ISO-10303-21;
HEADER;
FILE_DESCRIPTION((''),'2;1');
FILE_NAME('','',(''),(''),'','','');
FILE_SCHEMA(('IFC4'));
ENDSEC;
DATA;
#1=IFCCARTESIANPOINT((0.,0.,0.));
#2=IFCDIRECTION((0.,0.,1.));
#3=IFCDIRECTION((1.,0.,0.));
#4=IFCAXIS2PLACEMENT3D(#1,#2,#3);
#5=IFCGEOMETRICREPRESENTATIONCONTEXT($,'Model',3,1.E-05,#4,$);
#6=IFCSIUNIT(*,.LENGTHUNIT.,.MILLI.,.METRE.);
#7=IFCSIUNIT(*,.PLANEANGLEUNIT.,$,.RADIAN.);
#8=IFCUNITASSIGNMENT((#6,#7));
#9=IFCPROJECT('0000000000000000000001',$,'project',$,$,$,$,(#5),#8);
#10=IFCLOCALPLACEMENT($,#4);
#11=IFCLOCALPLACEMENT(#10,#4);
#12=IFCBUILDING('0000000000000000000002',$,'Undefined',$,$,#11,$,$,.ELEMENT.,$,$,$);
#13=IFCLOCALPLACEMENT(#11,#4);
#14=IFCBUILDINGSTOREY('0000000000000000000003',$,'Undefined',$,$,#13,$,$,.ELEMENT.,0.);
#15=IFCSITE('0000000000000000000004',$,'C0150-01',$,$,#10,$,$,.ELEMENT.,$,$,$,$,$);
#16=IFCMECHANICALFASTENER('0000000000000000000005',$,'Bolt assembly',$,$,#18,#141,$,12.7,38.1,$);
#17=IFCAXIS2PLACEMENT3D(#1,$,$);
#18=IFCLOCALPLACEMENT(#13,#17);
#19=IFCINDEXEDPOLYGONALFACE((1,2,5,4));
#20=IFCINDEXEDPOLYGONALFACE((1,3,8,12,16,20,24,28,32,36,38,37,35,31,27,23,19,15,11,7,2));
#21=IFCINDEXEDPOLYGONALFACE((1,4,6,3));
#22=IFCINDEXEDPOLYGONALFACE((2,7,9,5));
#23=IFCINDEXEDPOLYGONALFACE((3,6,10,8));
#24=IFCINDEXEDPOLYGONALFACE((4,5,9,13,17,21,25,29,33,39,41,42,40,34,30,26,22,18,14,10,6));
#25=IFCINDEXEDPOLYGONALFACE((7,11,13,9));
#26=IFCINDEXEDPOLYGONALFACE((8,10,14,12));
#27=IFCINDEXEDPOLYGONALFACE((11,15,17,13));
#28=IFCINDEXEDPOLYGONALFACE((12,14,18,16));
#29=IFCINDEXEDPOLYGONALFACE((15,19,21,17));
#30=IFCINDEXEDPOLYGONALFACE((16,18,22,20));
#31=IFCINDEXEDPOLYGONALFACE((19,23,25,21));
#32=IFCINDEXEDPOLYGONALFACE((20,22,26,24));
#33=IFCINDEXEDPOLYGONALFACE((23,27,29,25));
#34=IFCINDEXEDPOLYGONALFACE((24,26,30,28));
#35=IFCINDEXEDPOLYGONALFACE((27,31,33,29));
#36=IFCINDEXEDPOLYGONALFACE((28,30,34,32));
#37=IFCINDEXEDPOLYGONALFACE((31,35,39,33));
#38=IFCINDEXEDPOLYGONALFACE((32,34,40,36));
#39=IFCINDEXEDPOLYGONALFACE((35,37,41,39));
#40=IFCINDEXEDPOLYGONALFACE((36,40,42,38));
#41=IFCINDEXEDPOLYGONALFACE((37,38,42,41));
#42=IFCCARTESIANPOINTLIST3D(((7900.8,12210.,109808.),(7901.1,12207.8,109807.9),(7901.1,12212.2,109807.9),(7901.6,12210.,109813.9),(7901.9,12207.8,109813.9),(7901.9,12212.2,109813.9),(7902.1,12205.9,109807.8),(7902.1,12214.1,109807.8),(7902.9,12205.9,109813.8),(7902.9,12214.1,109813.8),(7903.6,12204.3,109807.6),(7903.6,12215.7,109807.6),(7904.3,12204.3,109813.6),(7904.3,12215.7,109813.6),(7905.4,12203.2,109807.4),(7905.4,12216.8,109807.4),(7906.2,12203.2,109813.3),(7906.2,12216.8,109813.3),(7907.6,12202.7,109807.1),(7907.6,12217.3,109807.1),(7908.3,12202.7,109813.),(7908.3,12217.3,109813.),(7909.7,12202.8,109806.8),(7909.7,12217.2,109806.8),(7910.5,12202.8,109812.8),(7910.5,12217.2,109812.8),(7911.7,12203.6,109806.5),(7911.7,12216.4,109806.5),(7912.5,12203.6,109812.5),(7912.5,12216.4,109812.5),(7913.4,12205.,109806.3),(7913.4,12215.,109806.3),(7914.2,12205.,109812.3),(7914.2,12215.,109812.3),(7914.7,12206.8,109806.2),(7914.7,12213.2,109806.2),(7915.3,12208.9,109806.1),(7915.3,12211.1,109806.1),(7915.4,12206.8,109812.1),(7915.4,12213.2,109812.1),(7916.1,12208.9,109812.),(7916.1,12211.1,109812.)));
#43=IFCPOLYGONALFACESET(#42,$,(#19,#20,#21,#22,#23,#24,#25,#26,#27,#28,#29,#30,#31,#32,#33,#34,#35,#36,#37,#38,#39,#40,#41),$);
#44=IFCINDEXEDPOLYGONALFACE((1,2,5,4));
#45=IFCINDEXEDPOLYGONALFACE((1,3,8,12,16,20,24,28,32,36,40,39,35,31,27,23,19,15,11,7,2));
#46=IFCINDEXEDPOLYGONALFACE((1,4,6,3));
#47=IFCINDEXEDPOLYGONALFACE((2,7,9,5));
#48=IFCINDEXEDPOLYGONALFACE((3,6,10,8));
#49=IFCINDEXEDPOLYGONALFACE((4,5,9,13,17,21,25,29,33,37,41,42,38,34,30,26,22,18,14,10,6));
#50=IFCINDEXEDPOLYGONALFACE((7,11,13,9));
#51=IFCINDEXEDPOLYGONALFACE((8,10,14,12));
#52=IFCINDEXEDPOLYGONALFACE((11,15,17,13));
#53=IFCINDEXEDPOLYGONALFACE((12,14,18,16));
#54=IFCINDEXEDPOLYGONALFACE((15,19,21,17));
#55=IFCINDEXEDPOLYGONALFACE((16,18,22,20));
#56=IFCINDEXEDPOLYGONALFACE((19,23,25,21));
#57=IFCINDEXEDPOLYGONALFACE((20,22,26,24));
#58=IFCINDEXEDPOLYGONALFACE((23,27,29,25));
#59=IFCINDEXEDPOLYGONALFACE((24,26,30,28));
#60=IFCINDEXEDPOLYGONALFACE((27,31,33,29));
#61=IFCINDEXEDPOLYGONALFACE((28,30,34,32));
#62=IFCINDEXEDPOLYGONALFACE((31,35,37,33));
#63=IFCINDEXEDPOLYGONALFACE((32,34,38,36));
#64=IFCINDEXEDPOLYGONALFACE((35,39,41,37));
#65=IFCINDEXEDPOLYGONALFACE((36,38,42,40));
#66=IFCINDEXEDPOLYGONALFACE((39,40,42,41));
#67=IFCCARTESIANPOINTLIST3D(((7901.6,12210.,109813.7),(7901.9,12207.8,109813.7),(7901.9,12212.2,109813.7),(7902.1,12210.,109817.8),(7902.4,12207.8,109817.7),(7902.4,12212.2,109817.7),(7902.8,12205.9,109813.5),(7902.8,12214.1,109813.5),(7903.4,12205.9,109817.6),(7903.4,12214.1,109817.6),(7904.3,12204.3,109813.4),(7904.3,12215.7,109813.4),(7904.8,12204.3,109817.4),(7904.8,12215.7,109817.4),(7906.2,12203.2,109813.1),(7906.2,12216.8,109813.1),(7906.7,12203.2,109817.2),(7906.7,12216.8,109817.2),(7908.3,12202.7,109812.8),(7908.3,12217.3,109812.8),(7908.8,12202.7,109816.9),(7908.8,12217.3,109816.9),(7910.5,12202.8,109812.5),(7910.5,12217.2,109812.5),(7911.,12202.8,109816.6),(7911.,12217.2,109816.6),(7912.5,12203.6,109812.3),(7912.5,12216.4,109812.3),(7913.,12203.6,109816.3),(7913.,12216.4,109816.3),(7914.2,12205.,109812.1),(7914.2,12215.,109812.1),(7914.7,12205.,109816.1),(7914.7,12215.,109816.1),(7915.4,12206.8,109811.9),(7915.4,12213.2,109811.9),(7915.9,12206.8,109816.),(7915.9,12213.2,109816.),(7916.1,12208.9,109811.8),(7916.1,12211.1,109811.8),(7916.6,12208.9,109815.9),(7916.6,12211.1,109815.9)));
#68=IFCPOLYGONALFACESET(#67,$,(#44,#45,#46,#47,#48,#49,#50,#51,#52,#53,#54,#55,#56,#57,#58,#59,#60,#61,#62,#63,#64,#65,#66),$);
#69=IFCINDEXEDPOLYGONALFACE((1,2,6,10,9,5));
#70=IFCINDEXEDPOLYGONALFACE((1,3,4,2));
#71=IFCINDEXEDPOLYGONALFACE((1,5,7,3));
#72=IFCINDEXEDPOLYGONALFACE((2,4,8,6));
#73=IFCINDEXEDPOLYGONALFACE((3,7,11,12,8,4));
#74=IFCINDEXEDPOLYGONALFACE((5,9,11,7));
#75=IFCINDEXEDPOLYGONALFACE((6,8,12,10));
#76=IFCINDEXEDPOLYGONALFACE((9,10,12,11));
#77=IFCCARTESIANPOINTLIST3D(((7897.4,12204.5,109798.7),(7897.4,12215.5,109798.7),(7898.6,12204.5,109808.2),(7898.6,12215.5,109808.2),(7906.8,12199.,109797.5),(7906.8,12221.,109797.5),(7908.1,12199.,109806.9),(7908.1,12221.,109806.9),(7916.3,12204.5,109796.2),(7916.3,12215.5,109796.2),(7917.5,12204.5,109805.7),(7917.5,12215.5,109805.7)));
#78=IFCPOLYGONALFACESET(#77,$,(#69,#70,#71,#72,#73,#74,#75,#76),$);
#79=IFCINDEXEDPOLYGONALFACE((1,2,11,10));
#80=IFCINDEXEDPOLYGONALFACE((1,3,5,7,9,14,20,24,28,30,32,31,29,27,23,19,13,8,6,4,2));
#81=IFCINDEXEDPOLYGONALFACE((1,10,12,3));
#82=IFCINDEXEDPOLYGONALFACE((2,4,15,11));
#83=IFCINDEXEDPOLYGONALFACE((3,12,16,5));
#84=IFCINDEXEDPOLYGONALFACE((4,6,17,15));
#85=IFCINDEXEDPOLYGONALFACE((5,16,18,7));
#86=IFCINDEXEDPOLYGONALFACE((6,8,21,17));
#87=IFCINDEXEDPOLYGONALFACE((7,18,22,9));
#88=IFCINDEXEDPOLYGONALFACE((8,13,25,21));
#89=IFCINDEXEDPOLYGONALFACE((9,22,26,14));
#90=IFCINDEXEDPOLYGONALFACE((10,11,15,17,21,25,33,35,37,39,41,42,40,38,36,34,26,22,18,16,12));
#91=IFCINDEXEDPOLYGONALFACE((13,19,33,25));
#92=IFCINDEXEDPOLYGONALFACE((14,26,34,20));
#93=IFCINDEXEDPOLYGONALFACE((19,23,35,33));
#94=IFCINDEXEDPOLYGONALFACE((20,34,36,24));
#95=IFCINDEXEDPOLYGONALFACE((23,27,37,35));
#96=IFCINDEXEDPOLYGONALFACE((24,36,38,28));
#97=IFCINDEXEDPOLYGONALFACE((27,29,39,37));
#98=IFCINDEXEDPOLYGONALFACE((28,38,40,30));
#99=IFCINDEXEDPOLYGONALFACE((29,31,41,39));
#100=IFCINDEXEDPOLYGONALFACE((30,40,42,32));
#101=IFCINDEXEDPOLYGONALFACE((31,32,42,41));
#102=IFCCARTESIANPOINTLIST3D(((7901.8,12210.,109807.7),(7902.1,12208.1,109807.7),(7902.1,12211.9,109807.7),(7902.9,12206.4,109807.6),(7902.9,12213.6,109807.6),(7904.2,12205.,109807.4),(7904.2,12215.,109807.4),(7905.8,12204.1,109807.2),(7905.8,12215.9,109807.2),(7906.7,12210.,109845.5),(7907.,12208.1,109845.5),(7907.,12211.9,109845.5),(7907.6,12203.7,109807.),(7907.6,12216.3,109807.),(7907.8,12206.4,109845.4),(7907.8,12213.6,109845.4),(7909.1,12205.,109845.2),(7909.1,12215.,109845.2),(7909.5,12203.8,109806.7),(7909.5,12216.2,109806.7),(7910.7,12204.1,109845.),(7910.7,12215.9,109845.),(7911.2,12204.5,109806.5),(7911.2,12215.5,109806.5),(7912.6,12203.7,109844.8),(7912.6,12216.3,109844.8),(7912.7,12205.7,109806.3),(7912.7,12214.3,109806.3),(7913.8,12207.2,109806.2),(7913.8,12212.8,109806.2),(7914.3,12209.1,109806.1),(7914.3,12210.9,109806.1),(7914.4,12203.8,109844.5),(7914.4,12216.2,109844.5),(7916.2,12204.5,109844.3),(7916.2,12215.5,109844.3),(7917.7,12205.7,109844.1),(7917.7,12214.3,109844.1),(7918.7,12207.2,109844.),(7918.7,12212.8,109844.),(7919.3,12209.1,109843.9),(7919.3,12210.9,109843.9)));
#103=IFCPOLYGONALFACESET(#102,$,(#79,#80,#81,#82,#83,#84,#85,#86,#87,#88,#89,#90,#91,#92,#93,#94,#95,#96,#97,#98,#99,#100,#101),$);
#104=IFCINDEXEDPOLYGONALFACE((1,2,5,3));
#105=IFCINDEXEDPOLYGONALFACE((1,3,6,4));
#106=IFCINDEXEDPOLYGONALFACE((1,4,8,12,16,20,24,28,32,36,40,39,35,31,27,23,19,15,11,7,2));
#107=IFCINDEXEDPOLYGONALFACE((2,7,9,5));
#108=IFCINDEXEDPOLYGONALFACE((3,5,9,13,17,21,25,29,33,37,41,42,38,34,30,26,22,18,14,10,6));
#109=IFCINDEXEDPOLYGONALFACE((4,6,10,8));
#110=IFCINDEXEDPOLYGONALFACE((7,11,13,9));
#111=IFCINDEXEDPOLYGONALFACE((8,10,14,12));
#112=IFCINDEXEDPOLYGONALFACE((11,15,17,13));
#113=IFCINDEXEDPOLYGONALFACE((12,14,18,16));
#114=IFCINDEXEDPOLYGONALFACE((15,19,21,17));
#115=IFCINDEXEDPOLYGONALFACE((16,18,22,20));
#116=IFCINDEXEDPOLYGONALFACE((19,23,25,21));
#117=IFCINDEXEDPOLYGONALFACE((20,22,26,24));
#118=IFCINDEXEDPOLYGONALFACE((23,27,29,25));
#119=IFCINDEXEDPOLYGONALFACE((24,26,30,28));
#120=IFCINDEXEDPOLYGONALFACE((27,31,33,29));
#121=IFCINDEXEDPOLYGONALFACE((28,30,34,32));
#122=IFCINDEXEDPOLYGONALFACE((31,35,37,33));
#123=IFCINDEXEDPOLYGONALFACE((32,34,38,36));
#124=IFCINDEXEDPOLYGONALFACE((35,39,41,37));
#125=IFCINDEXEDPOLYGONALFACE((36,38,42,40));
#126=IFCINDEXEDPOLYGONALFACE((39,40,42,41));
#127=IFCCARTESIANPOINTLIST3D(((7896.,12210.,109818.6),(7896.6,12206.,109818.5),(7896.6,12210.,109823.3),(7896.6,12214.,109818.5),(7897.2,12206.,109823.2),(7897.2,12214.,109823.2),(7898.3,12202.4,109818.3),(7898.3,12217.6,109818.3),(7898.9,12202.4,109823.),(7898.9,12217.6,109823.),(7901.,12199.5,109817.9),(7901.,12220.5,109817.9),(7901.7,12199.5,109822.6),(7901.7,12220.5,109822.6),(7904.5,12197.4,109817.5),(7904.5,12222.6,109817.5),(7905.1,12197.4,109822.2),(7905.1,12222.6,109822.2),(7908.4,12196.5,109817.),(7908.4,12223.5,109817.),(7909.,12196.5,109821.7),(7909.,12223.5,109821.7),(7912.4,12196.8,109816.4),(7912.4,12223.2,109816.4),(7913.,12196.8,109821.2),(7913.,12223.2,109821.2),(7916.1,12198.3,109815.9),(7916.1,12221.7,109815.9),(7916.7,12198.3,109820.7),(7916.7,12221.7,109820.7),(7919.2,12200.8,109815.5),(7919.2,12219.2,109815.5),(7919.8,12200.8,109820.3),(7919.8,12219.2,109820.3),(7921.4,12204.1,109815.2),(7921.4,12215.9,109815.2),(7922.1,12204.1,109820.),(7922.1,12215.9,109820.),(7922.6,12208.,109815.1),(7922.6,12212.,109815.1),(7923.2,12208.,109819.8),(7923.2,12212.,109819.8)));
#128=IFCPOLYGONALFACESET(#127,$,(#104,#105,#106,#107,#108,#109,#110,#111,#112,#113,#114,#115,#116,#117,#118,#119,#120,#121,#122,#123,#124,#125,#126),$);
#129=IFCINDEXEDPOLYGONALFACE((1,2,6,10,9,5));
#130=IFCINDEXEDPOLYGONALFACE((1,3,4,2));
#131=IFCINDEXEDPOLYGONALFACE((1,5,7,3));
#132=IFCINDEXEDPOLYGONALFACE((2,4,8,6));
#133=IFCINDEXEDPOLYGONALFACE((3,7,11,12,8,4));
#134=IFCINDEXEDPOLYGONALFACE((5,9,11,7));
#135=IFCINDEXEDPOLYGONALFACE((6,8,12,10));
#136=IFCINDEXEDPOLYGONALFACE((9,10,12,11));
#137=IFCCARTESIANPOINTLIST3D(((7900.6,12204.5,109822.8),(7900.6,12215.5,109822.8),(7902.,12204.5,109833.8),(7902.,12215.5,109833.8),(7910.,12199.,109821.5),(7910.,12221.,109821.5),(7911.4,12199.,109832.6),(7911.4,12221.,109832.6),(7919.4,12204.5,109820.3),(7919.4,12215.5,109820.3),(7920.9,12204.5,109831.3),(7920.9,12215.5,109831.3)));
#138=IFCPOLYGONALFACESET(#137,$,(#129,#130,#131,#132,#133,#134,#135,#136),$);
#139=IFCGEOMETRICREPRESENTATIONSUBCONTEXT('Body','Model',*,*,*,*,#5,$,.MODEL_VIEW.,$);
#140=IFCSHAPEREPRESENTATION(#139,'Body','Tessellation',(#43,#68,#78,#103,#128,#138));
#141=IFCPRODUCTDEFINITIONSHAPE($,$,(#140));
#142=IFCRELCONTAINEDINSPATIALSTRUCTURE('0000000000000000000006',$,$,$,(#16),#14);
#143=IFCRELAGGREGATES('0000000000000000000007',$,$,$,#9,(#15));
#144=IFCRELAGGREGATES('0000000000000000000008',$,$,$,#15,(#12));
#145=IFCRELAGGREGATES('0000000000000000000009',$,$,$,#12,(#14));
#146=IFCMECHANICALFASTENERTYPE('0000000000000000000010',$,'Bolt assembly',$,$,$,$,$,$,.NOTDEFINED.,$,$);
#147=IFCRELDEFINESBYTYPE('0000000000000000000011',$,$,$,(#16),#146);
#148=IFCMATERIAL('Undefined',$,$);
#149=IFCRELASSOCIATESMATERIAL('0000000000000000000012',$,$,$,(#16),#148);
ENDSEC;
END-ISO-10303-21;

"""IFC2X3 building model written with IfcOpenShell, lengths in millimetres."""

from ifc_helpers import new_model, si_unit, frame, origin_with_axes, origin_2d_with_axis, place, context, subcontext, project, spatial, polyline, circle, outline, extrude, source, transform, mapped, material, type_object, element, save


model = new_model("IFC2X3")

# Units and contexts
model_context = context("Model", 3, precision=1e-05, world=origin_with_axes())
body_context = subcontext(model_context, "Body", "Model", "MODEL_VIEW")
ifc_project = project(units=[si_unit("LENGTHUNIT", "METRE", prefix="MILLI"), si_unit("PLANEANGLEUNIT", "RADIAN")], contexts=[model_context])

# Site, building, storey
site_placement = place(None, origin_with_axes())
site = spatial("IfcSite", under=ifc_project, at=site_placement, Name="C0150-01", CompositionType="ELEMENT")
building_placement = place(site_placement, origin_with_axes())
building = spatial("IfcBuilding", under=site, at=building_placement, Name="Undefined", CompositionType="ELEMENT")
storey_placement = place(building_placement, origin_with_axes())
storey = spatial("IfcBuildingStorey", under=building, at=storey_placement, Name="Undefined", CompositionType="ELEMENT", Elevation=0.0)

# Mechanical fastener
ifc_material_1 = material(Name="Undefined")
mechanical_fastener_type = type_object("IfcMechanicalFastenerType", Name="Bolt assembly")
shared_shape_1 = source(origin_with_axes(), body_context, "Body", "SweptSolid", [
    extrude(circle(Radius=7.3, at=origin_2d_with_axis()), frame((0.0, -9.9, 0.0), z_axis=(0.0, 1.0, 0.0), x_axis=(1.0, 0.0, 0.0)), (0.0, 0.0, 1.0), 6.0),
    extrude(circle(Radius=7.3, at=origin_2d_with_axis()), frame((0.0, -4.1, 0.0), z_axis=(0.0, 1.0, 0.0), x_axis=(1.0, 0.0, 0.0)), (0.0, 0.0, 1.0), 4.1),
    extrude(outline(polyline([(9.5, -5.5), (9.5, 5.5), (0.0, 11.0), (-9.5, 5.5), (-9.5, -5.5), (0.0, -11.0), (9.5, -5.5)])), frame((0.0, -19.5, 0.0), z_axis=(0.0, 1.0, 0.0), x_axis=(1.0, 0.0, 0.0)), (0.0, 0.0, 1.0), 9.5),
    extrude(circle(Radius=6.3, at=origin_2d_with_axis()), frame((0.0, -10.0, 0.0), z_axis=(0.0, 1.0, 0.0), x_axis=(1.0, 0.0, 0.0)), (0.0, 0.0, 1.0), 38.1),
    extrude(circle(Radius=13.5, at=origin_2d_with_axis()), frame((0.0, 0.0, 0.0), z_axis=(0.0, 1.0, 0.0), x_axis=(1.0, 0.0, 0.0)), (0.0, 0.0, 1.0), 4.8),
    extrude(outline(polyline([(9.5, -5.5), (9.5, 5.5), (0.0, 11.0), (-9.5, 5.5), (-9.5, -5.5), (0.0, -11.0), (9.5, -5.5)])), frame((0.0, 4.8, 0.0), z_axis=(0.0, 1.0, 0.0), x_axis=(1.0, 0.0, 0.0)), (0.0, 0.0, 1.0), 11.1),
])
for number, where, z_axis, x_axis, name in (
    (1, (7909.4, 12210.0, 109816.8), (0.0, 1.0, 0.0), (-0.991507, 0.0, 0.130054), "Bolt assembly"),
):
    element("IfcMechanicalFastener", number, at=place(storey_placement, frame(where, z_axis=z_axis, x_axis=x_axis)), inside=storey, type_object=mechanical_fastener_type, material=ifc_material_1, Name=name, NominalDiameter=12.7, NominalLength=38.1, context=body_context, shape_type="MappedRepresentation", body=[
        mapped(shared_shape_1, transform((0.0, 0.0, 0.0))),
    ])

save(model, "model.ifc")
